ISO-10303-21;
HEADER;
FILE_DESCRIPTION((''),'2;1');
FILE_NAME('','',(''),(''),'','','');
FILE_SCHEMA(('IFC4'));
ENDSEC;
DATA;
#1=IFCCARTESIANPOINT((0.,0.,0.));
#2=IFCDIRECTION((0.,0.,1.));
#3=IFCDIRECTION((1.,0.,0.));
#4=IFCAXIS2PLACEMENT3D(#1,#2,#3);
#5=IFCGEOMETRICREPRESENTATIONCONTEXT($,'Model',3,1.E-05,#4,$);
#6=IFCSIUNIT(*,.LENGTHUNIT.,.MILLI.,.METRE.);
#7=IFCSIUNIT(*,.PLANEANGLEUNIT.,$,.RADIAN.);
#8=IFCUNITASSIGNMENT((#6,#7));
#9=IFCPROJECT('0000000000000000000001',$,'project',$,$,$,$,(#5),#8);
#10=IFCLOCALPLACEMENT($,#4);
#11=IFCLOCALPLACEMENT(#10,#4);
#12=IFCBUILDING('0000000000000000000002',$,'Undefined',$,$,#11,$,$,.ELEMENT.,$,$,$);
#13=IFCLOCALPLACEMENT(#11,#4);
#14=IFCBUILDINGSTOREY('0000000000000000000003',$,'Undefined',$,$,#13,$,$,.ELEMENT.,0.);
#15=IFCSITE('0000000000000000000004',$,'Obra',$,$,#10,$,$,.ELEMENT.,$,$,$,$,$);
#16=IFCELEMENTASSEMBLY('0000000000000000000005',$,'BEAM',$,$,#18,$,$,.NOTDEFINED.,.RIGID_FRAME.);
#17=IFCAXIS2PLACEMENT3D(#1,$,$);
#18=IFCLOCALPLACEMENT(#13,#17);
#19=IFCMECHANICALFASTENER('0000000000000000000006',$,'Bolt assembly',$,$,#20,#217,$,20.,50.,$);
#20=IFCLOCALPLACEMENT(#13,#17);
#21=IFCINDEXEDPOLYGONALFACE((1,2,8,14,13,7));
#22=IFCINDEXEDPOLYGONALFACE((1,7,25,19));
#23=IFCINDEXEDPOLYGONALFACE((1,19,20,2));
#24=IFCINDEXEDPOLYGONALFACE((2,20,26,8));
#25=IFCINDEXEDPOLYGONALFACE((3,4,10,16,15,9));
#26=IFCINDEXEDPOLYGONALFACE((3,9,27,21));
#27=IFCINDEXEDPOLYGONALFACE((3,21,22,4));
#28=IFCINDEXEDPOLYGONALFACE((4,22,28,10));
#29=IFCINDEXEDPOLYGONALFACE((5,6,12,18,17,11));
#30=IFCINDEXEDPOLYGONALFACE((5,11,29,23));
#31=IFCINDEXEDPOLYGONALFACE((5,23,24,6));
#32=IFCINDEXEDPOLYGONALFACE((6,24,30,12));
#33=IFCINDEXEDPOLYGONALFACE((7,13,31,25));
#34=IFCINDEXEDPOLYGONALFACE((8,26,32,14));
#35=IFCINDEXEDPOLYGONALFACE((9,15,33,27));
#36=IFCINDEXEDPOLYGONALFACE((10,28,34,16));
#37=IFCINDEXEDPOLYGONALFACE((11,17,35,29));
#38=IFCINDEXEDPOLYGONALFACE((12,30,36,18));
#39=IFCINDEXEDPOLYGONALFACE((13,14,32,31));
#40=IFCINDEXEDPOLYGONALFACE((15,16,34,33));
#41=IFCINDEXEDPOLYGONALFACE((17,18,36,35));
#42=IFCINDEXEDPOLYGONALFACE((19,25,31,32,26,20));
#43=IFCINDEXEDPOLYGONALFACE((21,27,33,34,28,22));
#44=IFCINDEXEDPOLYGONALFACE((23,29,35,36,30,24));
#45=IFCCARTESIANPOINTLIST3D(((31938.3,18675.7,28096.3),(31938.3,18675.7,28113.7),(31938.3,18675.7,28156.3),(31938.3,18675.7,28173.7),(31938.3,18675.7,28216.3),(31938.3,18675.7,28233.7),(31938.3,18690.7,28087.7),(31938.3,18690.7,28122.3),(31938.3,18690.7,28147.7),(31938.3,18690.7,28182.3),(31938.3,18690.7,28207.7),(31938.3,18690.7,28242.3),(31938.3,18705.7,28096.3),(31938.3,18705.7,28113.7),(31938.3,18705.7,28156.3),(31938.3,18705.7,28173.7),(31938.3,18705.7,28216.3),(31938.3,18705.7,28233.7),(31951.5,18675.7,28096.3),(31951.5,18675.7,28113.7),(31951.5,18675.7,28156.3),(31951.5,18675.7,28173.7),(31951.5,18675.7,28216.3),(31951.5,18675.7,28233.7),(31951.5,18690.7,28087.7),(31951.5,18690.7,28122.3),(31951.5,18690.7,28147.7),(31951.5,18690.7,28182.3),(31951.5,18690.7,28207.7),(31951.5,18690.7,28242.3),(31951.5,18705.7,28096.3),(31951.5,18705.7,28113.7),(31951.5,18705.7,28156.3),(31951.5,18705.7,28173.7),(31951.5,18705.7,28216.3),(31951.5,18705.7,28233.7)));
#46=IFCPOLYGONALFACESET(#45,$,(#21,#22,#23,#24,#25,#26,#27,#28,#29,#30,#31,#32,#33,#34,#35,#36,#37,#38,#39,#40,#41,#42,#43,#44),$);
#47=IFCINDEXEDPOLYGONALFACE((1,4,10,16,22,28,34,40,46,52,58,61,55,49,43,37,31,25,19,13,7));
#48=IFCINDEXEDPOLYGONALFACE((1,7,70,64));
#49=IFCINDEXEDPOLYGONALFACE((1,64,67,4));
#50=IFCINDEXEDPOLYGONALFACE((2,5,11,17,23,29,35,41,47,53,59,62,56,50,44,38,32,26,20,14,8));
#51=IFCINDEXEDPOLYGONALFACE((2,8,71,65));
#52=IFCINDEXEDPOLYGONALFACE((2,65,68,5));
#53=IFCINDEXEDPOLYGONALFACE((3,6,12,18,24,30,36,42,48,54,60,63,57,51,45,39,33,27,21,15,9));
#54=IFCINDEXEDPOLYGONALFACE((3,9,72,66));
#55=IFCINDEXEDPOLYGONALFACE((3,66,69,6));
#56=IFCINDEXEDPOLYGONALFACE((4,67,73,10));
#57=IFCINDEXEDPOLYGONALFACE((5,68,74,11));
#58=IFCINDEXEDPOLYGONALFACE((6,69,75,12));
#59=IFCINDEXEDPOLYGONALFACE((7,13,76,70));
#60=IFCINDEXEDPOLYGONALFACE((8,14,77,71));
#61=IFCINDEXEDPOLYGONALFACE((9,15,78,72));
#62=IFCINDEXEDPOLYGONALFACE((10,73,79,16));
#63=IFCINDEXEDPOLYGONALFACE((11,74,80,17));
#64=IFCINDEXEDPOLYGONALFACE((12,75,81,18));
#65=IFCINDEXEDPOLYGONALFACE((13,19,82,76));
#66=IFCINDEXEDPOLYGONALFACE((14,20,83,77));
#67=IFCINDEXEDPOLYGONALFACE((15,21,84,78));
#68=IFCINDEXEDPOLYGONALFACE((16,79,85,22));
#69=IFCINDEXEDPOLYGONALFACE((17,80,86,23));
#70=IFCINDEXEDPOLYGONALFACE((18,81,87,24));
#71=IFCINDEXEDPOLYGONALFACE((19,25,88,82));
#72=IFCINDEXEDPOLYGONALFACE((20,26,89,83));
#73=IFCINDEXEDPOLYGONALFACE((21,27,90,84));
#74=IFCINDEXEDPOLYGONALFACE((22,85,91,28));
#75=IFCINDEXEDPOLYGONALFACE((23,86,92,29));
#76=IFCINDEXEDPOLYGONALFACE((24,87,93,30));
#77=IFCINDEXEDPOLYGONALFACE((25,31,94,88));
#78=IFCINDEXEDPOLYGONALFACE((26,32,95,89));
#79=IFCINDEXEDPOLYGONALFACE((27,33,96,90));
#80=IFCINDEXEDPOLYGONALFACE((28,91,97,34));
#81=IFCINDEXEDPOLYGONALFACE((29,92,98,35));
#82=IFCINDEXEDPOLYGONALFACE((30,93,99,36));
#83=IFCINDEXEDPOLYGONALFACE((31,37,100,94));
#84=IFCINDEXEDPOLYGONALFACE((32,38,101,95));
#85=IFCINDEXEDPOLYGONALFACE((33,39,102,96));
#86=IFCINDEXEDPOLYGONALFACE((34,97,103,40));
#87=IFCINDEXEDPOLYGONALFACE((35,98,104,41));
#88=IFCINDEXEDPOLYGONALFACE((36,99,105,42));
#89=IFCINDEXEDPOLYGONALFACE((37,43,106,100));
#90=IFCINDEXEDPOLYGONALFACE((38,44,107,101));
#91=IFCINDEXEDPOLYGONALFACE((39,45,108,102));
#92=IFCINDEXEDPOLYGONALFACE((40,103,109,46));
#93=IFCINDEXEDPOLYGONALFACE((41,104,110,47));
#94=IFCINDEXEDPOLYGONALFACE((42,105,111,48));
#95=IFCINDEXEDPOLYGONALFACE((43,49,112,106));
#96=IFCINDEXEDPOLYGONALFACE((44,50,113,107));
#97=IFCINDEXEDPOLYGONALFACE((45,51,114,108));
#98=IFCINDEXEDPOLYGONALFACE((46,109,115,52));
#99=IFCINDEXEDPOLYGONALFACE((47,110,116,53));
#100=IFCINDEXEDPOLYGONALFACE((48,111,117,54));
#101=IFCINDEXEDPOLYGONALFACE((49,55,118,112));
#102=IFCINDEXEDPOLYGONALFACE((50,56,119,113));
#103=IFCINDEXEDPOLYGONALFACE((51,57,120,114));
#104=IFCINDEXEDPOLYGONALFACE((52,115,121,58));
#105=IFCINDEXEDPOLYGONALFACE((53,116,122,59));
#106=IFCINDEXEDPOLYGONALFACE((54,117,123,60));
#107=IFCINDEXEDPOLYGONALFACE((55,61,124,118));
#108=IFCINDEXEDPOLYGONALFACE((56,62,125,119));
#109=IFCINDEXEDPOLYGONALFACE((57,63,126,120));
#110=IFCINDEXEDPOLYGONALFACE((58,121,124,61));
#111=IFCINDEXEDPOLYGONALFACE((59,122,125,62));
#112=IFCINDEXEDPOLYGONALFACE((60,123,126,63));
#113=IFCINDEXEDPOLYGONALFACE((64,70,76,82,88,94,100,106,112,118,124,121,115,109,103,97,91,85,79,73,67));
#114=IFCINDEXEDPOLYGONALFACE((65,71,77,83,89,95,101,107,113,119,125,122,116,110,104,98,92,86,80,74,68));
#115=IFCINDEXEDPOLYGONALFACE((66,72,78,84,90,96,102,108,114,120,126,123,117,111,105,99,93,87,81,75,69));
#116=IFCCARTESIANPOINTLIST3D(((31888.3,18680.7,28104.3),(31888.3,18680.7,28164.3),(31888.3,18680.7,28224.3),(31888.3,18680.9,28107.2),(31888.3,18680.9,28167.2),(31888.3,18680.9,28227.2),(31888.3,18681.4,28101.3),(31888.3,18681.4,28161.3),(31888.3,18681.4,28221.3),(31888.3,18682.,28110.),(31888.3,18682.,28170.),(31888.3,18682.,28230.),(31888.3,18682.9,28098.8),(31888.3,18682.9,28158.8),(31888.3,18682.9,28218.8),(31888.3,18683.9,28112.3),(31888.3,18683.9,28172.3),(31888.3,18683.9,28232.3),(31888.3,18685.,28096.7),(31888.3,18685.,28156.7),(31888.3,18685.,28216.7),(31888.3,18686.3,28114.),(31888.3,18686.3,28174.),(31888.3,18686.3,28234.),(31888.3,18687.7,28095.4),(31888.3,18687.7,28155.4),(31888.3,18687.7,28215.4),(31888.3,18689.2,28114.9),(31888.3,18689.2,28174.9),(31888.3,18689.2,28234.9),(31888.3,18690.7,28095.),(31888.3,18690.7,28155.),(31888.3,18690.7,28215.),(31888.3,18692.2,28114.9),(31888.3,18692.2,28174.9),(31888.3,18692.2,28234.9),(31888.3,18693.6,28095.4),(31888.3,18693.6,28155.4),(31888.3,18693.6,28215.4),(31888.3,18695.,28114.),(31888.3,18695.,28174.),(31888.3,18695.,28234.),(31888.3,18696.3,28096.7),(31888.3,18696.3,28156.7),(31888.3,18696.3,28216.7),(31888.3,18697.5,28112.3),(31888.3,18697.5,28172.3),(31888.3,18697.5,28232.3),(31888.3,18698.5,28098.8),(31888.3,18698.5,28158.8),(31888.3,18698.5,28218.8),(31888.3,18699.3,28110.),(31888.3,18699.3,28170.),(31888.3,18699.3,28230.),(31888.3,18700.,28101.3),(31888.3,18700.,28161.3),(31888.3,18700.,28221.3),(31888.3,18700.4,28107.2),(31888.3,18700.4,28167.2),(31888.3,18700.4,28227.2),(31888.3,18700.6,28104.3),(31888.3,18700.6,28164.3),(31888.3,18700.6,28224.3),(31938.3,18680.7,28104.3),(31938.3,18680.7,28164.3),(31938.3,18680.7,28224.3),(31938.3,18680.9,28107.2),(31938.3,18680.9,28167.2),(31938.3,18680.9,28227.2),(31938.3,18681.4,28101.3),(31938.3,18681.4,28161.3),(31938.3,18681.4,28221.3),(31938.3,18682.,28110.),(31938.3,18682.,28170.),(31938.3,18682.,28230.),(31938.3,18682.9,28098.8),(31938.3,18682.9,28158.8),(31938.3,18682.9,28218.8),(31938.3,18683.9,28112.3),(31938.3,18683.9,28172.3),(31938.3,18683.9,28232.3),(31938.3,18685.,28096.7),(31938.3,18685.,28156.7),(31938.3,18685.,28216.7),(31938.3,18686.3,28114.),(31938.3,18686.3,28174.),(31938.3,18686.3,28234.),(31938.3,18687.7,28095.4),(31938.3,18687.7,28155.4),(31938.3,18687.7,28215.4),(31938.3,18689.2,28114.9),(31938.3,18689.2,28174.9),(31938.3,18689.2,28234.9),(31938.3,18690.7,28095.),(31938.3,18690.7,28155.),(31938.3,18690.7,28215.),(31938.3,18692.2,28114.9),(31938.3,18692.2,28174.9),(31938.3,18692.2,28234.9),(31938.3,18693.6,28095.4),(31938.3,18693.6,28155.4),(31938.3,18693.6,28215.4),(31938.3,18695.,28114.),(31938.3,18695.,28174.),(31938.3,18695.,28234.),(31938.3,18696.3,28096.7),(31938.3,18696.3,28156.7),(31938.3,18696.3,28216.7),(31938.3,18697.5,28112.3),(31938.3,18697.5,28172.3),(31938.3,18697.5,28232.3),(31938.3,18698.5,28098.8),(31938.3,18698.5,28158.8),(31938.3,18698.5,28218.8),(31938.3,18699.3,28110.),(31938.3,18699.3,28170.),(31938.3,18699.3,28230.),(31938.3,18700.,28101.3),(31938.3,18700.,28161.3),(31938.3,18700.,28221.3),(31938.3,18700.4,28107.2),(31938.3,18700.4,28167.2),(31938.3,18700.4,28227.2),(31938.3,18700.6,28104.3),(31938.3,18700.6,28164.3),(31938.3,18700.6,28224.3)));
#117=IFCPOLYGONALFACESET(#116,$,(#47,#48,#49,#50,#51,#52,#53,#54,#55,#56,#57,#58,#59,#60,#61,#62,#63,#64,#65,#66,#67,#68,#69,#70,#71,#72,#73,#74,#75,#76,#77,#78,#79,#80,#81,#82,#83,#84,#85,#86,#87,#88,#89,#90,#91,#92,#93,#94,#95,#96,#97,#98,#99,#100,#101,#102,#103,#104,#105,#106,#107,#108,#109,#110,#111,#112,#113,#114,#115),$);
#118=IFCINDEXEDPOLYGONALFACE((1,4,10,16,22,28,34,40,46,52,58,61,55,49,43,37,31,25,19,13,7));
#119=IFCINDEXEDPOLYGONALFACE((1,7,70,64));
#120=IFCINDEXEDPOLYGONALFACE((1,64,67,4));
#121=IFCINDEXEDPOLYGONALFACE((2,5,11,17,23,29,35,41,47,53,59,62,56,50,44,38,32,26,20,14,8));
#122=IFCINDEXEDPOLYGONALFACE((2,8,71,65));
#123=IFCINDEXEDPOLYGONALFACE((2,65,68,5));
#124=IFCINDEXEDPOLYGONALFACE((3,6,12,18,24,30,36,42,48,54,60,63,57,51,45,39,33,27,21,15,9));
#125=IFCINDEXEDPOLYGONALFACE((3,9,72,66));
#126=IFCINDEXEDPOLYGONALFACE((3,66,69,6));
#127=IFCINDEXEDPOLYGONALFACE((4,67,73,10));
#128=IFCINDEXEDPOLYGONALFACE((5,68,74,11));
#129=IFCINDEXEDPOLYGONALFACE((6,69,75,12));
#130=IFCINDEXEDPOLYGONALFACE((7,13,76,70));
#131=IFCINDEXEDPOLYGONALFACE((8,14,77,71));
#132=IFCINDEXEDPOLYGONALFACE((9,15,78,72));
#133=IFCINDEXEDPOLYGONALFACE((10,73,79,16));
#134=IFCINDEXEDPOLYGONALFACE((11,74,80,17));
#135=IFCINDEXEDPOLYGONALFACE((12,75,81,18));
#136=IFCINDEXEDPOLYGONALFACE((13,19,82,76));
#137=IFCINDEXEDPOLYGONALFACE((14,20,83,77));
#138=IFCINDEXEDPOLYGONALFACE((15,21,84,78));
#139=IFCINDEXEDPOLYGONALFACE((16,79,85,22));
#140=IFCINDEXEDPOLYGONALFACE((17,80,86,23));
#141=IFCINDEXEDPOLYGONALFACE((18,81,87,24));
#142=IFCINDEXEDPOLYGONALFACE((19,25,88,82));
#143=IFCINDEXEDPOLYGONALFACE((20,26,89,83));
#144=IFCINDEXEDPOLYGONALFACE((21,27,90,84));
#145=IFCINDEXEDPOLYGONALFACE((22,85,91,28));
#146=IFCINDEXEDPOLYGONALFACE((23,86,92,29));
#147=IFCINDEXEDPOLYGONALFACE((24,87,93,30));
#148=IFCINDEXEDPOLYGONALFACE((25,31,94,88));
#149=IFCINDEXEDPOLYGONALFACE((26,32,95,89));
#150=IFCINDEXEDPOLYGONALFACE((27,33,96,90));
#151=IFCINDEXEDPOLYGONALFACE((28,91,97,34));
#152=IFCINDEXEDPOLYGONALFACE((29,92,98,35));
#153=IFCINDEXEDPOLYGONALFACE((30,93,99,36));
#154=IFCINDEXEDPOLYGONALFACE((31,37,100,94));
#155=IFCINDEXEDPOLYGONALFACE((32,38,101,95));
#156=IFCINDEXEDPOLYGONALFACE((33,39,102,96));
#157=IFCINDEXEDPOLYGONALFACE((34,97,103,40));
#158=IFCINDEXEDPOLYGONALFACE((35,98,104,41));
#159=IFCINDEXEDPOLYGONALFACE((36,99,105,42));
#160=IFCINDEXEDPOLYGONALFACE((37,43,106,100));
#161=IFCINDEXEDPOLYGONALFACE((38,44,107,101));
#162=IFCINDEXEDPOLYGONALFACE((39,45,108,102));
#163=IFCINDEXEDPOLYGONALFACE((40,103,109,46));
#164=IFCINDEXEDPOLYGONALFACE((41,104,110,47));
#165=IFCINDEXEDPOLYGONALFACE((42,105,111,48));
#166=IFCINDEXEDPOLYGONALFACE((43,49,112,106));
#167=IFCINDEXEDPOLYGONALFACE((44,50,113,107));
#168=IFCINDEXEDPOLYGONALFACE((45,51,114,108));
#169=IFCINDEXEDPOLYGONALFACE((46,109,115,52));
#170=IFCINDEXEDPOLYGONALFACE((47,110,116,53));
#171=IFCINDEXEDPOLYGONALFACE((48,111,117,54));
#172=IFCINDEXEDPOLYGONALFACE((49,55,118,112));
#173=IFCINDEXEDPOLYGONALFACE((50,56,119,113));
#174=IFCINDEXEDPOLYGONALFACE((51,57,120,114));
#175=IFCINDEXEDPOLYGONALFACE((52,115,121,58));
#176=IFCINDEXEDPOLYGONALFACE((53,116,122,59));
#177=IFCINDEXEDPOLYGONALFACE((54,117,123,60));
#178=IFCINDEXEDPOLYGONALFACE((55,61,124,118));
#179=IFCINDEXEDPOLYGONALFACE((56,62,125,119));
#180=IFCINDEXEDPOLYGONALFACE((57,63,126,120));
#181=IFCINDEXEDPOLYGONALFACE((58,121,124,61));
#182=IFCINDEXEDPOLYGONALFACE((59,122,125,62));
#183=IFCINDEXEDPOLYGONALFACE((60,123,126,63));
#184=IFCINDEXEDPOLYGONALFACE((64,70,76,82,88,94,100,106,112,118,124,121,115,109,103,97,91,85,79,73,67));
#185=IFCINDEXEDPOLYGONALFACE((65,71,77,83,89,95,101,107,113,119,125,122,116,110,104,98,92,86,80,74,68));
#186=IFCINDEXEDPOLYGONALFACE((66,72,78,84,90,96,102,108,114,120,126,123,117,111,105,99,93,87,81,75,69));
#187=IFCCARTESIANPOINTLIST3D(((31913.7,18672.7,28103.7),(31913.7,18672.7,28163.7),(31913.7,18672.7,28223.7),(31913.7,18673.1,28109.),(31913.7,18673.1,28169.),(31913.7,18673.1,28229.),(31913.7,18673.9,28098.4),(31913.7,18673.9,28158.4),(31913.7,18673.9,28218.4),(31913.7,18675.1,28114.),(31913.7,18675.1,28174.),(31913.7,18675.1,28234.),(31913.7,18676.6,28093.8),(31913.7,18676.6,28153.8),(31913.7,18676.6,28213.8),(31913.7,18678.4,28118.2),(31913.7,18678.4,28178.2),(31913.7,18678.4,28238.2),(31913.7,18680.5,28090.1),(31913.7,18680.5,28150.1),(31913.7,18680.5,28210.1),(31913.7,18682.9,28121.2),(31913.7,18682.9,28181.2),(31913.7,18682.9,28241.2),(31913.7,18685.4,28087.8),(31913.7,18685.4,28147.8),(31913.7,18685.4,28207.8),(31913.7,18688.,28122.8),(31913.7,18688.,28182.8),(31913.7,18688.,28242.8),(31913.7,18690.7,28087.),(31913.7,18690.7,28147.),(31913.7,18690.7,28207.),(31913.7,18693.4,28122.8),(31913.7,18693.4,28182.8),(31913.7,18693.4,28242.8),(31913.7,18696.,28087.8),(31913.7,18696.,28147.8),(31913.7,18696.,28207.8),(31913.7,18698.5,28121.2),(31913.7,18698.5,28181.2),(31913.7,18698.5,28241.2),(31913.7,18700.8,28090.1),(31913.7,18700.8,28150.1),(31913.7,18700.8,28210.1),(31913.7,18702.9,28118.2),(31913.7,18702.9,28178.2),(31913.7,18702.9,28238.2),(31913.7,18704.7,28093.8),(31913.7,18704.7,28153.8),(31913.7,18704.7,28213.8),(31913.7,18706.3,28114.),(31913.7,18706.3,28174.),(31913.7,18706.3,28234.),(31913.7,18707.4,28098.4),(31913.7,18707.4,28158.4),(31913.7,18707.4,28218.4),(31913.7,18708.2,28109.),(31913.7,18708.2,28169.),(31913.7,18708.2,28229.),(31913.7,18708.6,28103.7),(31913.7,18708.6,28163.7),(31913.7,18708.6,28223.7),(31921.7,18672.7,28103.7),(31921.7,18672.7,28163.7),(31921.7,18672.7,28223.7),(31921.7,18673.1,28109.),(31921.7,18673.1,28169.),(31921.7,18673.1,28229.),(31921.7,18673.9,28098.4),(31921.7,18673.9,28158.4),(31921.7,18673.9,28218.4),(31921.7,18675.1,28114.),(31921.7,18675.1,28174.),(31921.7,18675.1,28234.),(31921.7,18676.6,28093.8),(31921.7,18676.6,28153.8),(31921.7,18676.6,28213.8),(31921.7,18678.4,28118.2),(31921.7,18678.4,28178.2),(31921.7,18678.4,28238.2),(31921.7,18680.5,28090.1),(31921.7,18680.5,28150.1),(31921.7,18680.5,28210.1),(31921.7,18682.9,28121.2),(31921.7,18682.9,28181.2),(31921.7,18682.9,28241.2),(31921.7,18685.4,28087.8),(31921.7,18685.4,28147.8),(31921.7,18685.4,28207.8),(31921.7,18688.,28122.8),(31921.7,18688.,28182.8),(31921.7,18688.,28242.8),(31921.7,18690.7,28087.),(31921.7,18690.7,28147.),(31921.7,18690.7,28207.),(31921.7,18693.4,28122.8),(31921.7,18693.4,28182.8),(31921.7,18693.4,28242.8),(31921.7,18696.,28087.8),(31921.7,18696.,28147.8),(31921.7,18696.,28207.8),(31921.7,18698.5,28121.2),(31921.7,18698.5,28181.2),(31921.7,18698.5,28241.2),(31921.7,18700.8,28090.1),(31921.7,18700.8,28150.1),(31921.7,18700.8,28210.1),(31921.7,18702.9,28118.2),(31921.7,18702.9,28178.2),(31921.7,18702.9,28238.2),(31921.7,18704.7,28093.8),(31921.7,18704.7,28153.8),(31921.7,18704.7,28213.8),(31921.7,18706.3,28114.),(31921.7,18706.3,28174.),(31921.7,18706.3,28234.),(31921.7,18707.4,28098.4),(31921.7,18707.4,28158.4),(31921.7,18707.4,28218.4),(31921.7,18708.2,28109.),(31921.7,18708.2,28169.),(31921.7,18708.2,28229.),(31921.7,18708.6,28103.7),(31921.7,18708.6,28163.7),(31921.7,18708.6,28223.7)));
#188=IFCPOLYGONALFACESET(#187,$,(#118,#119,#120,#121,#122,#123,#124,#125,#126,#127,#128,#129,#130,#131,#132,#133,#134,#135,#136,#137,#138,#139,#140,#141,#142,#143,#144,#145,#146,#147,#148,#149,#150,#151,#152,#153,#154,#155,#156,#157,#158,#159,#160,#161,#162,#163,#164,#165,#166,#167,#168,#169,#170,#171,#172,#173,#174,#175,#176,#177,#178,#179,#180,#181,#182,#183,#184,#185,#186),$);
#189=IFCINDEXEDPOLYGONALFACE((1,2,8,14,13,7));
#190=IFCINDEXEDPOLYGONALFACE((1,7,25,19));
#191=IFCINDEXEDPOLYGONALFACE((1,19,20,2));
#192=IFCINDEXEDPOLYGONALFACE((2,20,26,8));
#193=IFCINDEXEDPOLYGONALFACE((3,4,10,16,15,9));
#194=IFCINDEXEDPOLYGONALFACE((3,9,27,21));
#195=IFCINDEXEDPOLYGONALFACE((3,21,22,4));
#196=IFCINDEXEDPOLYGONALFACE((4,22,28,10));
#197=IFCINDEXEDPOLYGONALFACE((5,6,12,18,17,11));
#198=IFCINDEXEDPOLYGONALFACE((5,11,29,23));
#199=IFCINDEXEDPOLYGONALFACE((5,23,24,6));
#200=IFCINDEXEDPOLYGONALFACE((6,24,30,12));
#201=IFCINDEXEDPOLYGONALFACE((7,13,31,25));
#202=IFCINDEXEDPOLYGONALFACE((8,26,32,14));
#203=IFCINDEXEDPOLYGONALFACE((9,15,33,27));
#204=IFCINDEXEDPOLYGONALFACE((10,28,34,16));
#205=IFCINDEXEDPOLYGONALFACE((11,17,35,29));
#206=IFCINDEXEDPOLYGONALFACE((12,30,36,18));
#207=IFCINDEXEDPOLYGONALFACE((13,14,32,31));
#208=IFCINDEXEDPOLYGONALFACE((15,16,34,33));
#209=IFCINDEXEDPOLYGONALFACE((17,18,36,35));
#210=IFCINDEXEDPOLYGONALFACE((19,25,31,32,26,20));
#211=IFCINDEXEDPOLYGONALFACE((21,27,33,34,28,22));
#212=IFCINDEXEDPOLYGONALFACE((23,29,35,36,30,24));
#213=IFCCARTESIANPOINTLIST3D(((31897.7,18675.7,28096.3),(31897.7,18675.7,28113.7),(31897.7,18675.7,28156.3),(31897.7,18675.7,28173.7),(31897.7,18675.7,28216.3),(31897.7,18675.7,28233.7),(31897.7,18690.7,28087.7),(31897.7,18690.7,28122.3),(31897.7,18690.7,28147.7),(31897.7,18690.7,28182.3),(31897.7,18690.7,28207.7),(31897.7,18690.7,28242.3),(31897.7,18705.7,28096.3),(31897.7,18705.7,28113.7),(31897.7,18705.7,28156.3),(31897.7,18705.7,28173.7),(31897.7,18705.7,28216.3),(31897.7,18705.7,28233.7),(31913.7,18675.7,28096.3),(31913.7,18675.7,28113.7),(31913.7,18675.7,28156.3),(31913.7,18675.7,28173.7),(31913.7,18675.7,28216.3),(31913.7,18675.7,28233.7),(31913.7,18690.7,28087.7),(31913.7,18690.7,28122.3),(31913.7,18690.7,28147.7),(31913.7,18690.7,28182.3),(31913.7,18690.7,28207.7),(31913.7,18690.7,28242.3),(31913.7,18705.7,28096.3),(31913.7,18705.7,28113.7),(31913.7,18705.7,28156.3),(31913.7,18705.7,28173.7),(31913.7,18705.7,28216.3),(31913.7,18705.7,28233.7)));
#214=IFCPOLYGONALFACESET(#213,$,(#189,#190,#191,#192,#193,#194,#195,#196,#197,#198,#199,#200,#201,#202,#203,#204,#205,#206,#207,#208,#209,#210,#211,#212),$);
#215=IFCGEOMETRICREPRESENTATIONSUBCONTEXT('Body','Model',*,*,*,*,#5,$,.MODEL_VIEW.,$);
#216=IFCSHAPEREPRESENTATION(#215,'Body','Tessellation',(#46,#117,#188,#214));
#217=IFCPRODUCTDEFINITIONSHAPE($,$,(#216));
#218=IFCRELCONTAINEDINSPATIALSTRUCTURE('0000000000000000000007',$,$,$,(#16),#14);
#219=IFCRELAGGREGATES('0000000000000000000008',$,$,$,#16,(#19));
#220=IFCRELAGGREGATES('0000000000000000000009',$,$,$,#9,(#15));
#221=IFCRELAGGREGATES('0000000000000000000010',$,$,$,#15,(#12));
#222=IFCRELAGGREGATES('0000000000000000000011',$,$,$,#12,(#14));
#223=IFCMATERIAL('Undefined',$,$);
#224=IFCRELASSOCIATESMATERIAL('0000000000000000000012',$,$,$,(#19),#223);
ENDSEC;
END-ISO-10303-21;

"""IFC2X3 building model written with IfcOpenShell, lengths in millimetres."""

from ifc_helpers import new_model, si_unit, frame, origin_with_axes, origin_2d_with_axis, place, context, subcontext, project, spatial, polyline, circle, outline, extrude, source, transform, mapped, material, element, aggregate, save


model = new_model("IFC2X3")

# Units and contexts
model_context = context("Model", 3, precision=1e-05, world=origin_with_axes())
body_context = subcontext(model_context, "Body", "Model", "MODEL_VIEW")
ifc_project = project(units=[si_unit("LENGTHUNIT", "METRE", prefix="MILLI"), si_unit("PLANEANGLEUNIT", "RADIAN")], contexts=[model_context])

# Site, building, storey
site_placement = place(None, origin_with_axes())
site = spatial("IfcSite", under=ifc_project, at=site_placement, Name="Obra", CompositionType="ELEMENT")
building_placement = place(site_placement, origin_with_axes())
building = spatial("IfcBuilding", under=site, at=building_placement, Name="Undefined", CompositionType="ELEMENT")
storey_placement = place(building_placement, origin_with_axes())
storey = spatial("IfcBuildingStorey", under=building, at=storey_placement, Name="Undefined", CompositionType="ELEMENT", Elevation=0.0)

# Element assembly
assembly_1_placement = place(storey_placement, origin_with_axes())
assembly_1 = element("IfcElementAssembly", 1, at=assembly_1_placement, inside=storey, Name="BEAM", AssemblyPlace="NOTDEFINED", PredefinedType="RIGID_FRAME")

# Shared definitions
ifc_material_1 = material(Name="Undefined")
shared_shape_1 = source(origin_with_axes(), body_context, "Body", "SweptSolid", [
    extrude(outline(polyline([(17.3, 0.0), (8.7, 15.0), (-8.7, 15.0), (-17.3, 0.0), (-8.7, -15.0), (8.7, -15.0), (17.3, 0.0)])), frame((0.0, -26.5, 0.0), z_axis=(0.0, 1.0, 0.0), x_axis=(1.0, 0.0, 0.0)), (0.0, 0.0, 1.0), 13.2),
    extrude(circle(Radius=10.0, at=origin_2d_with_axis()), frame((0.0, -13.3, 0.0), z_axis=(0.0, 1.0, 0.0), x_axis=(1.0, 0.0, 0.0)), (0.0, 0.0, 1.0), 50.0),
    extrude(circle(Radius=18.0, at=origin_2d_with_axis()), frame((0.0, 3.3, 0.0), z_axis=(0.0, 1.0, 0.0), x_axis=(1.0, 0.0, 0.0)), (0.0, 0.0, 1.0), 8.0),
    extrude(outline(polyline([(17.3, 0.0), (8.7, 15.0), (-8.7, 15.0), (-17.3, 0.0), (-8.7, -15.0), (8.7, -15.0), (17.3, 0.0)])), frame((0.0, 11.3, 0.0), z_axis=(0.0, 1.0, 0.0), x_axis=(1.0, 0.0, 0.0)), (0.0, 0.0, 1.0), 16.0),
])

# Mechanical fastener
mechanical_fastener_1_placement = place(assembly_1_placement, frame((31925.0, 18640.7, 28265.0), z_axis=(0.0, 1.0, 0.0), x_axis=(0.0, 0.0, -1.0)))
mechanical_fastener_1 = element("IfcMechanicalFastener", 2, at=mechanical_fastener_1_placement, material=ifc_material_1, Name="Bolt assembly", NominalDiameter=20.0, NominalLength=50.0, context=body_context, shape_type="MappedRepresentation", body=[
    mapped(shared_shape_1, transform((40.0, 0.0, 50.0))),
    mapped(shared_shape_1, transform((100.0, 0.0, 50.0))),
    mapped(shared_shape_1, transform((160.0, 0.0, 50.0))),
])

aggregate(assembly_1, [mechanical_fastener_1])

save(model, "model.ifc")
